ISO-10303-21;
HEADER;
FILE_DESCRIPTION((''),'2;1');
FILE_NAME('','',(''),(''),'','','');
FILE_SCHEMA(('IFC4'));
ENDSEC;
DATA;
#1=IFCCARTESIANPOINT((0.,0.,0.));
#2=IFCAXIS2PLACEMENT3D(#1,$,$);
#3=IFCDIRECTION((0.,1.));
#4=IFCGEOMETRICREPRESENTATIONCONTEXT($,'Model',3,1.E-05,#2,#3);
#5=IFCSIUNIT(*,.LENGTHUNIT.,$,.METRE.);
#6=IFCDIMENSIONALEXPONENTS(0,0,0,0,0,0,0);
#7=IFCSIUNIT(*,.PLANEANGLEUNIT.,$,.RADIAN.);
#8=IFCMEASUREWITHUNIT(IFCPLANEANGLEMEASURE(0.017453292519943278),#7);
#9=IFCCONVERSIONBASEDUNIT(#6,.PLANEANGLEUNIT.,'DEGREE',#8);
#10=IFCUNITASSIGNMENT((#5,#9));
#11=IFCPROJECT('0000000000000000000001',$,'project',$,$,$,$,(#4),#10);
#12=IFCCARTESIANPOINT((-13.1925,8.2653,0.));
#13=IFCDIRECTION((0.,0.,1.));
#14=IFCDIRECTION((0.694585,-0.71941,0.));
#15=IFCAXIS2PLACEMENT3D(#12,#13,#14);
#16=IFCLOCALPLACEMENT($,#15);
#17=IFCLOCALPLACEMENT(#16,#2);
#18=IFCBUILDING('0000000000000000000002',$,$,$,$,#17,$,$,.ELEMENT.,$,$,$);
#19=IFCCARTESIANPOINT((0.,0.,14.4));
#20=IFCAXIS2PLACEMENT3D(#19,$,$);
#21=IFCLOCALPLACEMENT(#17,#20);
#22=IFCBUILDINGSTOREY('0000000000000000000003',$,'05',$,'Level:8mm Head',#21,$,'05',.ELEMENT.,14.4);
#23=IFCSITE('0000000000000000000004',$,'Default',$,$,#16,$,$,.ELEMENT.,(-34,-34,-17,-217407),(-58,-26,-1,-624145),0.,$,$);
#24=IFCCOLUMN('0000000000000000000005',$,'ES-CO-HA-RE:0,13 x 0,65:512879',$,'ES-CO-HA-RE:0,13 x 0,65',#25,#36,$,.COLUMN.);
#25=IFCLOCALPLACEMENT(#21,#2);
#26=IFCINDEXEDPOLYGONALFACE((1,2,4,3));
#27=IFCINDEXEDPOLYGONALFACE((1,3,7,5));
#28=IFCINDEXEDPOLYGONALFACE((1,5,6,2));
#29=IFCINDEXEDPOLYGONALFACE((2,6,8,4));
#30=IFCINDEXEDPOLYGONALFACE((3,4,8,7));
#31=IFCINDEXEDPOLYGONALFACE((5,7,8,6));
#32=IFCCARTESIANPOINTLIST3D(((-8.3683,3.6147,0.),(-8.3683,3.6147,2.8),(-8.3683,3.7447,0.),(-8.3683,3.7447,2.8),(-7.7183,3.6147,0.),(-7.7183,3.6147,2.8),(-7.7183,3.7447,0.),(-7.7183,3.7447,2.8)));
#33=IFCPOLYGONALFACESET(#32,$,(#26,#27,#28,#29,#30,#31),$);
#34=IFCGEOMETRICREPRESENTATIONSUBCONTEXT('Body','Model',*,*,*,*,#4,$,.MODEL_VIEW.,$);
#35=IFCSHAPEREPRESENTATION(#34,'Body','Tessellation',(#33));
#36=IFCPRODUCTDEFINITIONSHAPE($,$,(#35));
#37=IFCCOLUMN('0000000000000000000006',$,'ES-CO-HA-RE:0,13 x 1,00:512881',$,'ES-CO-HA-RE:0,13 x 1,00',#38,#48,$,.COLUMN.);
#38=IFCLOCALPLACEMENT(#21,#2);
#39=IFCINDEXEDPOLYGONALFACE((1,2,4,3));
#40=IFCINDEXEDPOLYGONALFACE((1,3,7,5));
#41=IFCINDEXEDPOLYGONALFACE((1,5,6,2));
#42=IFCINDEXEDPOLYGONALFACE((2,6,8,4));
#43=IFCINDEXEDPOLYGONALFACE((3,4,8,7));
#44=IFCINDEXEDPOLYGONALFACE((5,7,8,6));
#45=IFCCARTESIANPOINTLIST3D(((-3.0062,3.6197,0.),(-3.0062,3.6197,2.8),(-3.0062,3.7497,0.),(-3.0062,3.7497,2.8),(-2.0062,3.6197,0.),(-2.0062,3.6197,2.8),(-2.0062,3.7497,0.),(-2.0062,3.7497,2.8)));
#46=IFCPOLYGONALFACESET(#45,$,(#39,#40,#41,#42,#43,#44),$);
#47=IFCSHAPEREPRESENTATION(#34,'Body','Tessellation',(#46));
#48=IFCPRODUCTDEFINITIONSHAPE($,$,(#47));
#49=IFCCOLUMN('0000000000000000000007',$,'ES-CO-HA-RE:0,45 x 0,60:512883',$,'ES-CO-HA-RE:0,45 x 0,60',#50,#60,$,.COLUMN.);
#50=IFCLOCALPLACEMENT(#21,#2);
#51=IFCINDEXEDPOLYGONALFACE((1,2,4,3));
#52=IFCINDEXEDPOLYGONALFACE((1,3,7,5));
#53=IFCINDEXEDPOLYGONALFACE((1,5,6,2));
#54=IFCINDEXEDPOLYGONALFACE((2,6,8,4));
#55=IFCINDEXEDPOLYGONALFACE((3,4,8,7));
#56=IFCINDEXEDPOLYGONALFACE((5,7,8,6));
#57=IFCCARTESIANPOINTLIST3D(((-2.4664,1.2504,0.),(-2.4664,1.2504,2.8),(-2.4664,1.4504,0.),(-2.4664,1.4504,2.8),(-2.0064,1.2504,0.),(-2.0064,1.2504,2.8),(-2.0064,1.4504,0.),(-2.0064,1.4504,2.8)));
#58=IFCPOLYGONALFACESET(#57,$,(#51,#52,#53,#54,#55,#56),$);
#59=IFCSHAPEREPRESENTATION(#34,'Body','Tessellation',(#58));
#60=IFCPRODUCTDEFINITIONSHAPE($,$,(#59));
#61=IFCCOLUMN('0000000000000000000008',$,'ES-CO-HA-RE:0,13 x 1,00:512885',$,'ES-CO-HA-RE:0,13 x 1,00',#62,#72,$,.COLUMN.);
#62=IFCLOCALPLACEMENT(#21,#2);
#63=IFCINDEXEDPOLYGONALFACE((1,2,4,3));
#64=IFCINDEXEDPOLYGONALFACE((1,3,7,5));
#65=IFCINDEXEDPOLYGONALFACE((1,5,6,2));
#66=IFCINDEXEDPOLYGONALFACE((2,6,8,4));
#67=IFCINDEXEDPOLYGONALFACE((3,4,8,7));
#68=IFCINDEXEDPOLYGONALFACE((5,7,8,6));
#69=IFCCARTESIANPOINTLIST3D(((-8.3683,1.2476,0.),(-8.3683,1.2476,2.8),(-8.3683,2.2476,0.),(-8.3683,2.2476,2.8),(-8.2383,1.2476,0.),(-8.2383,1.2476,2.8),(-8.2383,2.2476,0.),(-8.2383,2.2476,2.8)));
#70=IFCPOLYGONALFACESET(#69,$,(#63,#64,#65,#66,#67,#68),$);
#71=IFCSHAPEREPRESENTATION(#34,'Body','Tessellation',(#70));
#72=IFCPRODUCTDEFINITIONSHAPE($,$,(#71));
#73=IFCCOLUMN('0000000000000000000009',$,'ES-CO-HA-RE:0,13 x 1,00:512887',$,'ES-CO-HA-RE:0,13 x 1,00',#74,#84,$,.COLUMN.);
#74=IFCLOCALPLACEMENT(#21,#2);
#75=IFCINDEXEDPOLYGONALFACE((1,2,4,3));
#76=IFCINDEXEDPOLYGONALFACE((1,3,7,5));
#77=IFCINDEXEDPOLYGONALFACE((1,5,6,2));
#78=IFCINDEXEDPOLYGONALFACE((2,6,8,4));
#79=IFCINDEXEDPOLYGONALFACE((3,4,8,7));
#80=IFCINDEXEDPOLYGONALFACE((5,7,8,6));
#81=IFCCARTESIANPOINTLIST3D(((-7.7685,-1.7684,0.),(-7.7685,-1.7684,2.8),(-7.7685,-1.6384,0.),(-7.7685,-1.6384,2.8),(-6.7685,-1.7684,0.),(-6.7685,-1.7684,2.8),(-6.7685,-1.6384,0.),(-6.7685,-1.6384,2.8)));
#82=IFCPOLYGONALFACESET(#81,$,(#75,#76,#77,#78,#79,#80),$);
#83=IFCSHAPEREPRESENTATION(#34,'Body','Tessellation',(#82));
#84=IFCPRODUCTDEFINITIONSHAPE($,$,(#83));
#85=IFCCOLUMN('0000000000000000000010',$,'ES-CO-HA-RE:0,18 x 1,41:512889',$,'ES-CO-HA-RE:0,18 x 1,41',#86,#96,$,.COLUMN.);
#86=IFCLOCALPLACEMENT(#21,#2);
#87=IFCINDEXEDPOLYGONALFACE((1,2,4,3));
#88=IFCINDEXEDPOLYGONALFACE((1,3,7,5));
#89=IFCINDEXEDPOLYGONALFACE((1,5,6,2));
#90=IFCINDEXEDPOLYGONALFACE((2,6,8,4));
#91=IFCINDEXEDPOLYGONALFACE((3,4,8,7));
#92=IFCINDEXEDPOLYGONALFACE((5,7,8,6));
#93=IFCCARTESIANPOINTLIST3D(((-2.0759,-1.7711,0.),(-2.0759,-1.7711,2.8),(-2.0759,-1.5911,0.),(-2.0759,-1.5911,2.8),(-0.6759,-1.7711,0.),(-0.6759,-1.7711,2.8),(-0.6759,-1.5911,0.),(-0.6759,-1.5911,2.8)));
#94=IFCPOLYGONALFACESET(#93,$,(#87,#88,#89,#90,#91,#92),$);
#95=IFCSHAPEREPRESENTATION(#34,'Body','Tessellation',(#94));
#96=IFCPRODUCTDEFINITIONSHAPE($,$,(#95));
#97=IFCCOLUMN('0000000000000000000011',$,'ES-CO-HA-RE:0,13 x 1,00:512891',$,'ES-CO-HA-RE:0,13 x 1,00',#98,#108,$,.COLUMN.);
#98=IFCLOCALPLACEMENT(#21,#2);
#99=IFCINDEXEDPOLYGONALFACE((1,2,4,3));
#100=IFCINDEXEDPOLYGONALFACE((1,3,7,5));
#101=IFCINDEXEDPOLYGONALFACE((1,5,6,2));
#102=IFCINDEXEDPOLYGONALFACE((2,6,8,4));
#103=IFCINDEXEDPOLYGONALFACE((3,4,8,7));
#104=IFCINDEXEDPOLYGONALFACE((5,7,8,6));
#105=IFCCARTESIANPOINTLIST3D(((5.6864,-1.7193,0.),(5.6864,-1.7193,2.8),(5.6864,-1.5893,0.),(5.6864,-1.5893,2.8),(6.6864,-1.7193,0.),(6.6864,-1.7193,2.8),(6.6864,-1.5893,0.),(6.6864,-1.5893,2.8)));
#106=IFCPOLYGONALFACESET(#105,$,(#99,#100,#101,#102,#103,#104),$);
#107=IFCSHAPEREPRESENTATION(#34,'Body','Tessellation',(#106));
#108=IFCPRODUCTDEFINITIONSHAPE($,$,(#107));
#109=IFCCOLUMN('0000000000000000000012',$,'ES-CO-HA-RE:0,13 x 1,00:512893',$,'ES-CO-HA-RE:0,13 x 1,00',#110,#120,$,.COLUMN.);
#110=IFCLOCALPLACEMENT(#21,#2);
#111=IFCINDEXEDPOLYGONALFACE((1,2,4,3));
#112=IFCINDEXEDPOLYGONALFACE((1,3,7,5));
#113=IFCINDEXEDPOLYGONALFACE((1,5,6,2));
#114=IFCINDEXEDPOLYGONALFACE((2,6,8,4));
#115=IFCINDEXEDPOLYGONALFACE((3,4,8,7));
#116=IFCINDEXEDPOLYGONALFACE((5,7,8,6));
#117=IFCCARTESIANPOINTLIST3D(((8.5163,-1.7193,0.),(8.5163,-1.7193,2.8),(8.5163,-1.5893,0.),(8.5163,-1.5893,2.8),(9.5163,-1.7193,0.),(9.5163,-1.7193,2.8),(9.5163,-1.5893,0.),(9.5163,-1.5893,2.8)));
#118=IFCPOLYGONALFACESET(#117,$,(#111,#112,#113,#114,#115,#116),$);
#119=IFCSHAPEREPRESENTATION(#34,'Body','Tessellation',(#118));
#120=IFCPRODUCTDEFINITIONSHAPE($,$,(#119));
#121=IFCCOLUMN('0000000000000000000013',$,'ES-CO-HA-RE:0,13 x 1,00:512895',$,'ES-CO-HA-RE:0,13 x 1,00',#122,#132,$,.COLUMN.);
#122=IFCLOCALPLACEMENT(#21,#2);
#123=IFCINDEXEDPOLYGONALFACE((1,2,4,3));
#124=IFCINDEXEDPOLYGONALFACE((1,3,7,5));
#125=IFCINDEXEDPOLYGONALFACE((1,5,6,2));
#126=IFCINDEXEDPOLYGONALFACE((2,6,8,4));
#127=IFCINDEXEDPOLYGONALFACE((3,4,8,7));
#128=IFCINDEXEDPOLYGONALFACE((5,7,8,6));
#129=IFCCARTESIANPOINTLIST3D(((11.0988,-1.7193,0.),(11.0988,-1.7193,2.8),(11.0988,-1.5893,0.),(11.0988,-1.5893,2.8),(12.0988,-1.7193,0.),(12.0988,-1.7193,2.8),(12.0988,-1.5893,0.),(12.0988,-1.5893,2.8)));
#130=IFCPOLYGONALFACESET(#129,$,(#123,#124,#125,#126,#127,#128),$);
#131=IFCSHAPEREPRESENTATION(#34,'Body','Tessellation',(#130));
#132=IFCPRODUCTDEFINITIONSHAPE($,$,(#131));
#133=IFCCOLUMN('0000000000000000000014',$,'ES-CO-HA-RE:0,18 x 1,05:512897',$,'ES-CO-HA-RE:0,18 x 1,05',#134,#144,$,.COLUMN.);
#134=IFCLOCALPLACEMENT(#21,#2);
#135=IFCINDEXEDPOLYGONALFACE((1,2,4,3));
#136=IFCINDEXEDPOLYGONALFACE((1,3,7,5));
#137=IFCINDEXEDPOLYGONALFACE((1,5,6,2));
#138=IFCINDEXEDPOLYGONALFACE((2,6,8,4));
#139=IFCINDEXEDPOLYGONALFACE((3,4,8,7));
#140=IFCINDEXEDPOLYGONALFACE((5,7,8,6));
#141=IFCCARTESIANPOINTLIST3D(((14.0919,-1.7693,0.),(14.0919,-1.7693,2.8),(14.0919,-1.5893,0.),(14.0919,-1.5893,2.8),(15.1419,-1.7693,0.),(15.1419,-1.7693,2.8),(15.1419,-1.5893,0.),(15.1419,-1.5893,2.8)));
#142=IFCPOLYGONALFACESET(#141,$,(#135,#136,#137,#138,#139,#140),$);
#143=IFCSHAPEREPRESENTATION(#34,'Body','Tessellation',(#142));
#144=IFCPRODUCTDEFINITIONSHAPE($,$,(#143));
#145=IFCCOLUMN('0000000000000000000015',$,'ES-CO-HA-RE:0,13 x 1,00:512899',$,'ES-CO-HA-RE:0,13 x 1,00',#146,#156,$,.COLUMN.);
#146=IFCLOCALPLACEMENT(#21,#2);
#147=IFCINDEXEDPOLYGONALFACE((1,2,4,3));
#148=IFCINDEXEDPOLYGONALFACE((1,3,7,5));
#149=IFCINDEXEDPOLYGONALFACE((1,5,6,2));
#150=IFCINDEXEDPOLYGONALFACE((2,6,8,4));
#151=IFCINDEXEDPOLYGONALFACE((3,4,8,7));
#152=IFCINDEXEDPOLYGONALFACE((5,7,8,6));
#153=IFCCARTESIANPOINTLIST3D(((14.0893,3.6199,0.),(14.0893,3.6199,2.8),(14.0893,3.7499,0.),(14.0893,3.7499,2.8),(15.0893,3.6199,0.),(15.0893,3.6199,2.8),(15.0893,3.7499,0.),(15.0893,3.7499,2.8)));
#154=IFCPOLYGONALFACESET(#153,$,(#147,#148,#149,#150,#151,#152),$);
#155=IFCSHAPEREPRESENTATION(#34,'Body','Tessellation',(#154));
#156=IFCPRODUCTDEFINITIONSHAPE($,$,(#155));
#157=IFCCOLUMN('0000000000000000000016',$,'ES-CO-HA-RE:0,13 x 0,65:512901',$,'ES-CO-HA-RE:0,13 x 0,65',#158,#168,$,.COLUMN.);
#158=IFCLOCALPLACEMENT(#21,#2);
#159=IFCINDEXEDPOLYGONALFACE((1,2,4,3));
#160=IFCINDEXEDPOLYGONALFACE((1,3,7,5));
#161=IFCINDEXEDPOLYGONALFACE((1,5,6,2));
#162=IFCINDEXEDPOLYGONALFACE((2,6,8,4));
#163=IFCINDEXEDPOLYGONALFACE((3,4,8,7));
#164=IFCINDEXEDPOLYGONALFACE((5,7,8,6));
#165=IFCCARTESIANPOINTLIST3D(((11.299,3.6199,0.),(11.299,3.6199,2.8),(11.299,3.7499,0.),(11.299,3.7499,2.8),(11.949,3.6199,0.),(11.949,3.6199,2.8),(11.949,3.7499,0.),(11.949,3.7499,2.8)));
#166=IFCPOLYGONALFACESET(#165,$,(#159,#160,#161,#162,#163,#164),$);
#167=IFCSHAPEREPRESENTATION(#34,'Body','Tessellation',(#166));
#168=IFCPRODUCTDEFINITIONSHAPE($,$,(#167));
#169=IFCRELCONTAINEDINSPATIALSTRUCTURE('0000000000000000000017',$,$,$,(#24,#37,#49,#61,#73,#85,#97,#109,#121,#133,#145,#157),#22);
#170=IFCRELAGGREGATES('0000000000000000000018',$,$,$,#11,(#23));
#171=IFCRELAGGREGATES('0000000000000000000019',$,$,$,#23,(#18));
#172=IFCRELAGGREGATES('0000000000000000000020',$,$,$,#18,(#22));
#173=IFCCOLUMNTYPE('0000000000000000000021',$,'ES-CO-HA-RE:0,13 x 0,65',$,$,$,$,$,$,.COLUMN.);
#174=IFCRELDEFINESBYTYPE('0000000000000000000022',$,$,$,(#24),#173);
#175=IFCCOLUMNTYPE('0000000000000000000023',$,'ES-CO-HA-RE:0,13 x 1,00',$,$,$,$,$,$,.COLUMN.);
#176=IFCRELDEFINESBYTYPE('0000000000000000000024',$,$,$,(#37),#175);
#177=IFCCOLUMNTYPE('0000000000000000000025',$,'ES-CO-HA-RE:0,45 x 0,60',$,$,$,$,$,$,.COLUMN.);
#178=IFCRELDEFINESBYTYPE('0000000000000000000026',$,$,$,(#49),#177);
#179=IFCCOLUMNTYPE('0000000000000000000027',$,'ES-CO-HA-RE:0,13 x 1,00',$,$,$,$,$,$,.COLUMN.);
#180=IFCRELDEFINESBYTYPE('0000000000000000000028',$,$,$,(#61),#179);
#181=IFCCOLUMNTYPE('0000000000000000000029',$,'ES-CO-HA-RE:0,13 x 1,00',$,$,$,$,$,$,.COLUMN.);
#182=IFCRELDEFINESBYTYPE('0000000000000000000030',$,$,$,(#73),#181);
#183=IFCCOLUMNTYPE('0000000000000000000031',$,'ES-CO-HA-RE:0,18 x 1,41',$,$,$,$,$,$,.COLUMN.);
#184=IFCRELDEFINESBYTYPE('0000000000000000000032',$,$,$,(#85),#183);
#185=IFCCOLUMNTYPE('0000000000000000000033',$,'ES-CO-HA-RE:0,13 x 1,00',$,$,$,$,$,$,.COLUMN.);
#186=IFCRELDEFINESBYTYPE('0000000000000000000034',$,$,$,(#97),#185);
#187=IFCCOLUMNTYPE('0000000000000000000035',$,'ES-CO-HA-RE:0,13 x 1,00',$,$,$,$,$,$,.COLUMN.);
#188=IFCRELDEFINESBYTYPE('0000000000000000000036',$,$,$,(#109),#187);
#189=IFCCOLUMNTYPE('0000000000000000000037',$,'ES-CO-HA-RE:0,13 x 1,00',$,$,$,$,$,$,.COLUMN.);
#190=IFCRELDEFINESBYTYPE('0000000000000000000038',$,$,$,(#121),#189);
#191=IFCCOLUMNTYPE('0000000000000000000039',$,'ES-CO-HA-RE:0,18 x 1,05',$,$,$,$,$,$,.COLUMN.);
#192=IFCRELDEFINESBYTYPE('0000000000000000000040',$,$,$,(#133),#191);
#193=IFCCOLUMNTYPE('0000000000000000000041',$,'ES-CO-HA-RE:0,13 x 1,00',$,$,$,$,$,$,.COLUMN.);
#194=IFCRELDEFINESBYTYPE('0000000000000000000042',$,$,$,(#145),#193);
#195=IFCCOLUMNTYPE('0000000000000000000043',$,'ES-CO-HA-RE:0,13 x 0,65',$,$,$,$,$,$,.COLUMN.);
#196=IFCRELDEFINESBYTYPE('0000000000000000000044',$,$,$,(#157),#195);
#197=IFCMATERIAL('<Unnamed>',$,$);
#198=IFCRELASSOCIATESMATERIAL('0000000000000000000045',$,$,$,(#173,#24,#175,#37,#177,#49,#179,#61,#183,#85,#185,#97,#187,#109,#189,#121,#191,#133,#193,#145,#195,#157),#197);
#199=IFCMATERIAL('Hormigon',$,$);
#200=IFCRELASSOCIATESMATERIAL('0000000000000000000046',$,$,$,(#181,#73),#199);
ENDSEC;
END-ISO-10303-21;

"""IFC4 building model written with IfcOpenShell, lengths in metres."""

from ifc_helpers import new_model, entity, si_unit, converted_unit, direction, frame, origin, place, context, subcontext, project, spatial, indexed_curve, outline, extrude, source, transform, mapped, material, type_object, type_shapes, element, save


model = new_model("IFC4")

# Units and contexts
model_context = context("Model", 3, precision=1e-05, world=origin(), true_north=direction((0.0, 1.0)))
body_context = subcontext(model_context, "Body", "Model", "MODEL_VIEW")
ifc_project = project(units=[si_unit("LENGTHUNIT", "METRE"), converted_unit("PLANEANGLEUNIT", "DEGREE", entity("IfcPlaneAngleMeasure", 0.017453292519943278), si_unit("PLANEANGLEUNIT", "RADIAN"), dimensions=[0, 0, 0, 0, 0, 0, 0])], contexts=[model_context])

# Site, building, storey
site_placement = place(None, frame((-13.1925, 8.2653, 0.0), z_axis=(0.0, 0.0, 1.0), x_axis=(0.694585, -0.71941, 0.0)))
site = spatial("IfcSite", under=ifc_project, at=site_placement, Name="Default", CompositionType="ELEMENT", RefLatitude=(-34, -34, -17, -217407), RefLongitude=(-58, -26, -1, -624145), RefElevation=0.0)
building_placement = place(site_placement, origin())
building = spatial("IfcBuilding", under=site, at=building_placement, CompositionType="ELEMENT")
storey_placement = place(building_placement, frame((0.0, 0.0, 14.4)))
storey = spatial("IfcBuildingStorey", under=building, at=storey_placement, Name="05", ObjectType="Level:8mm Head", LongName="05", CompositionType="ELEMENT", Elevation=14.4)

# Columns
ifc_material_1 = material(Name="<Unnamed>")
column_type_1 = type_object("IfcColumnType", Name="ES-CO-HA-RE:0,13 x 0,65", PredefinedType="COLUMN", material=ifc_material_1)
shared_shape_1 = source(origin(), body_context, "Body", "SweptSolid", [
    extrude(outline(indexed_curve([(-0.325, -0.065), (0.325, -0.065), (0.325, 0.065), (-0.325, 0.065), (-0.325, -0.065)], self_intersect=False)), frame((-8.0433, 3.6797, 14.4), z_axis=(0.0, 0.0, 1.0), x_axis=(-1.0, 0.0, 0.0)), (0.0, 0.0, 1.0), 2.8),
])
type_shapes(column_type_1, [shared_shape_1])
column_1_placement = place(storey_placement, frame((0.0, 0.0, -14.4)))
element("IfcColumn", 1, at=column_1_placement, inside=storey, type_object=column_type_1, material=ifc_material_1, Name="ES-CO-HA-RE:0,13 x 0,65:512879", ObjectType="ES-CO-HA-RE:0,13 x 0,65", PredefinedType="COLUMN", context=body_context, shape_type="MappedRepresentation", body=[
    mapped(shared_shape_1, transform((0.0, 0.0, 0.0), scale=1.0)),
])
column_type_2 = type_object("IfcColumnType", Name="ES-CO-HA-RE:0,13 x 1,00", PredefinedType="COLUMN", material=ifc_material_1)
shared_shape_2 = source(origin(), body_context, "Body", "SweptSolid", [
    extrude(outline(indexed_curve([(-0.5, -0.065), (0.5, -0.065), (0.5, 0.065), (-0.5, 0.065), (-0.5, -0.065)], self_intersect=False)), frame((-2.5062, 3.6847, 14.4), z_axis=(0.0, 0.0, 1.0), x_axis=(-1.0, 0.0, 0.0)), (0.0, 0.0, 1.0), 2.8),
])
type_shapes(column_type_2, [shared_shape_2])
column_2_placement = place(storey_placement, frame((0.0, 0.0, -14.4)))
element("IfcColumn", 2, at=column_2_placement, inside=storey, type_object=column_type_2, material=ifc_material_1, Name="ES-CO-HA-RE:0,13 x 1,00:512881", ObjectType="ES-CO-HA-RE:0,13 x 1,00", PredefinedType="COLUMN", context=body_context, shape_type="MappedRepresentation", body=[
    mapped(shared_shape_2, transform((0.0, 0.0, 0.0), scale=1.0)),
])
column_type_3 = type_object("IfcColumnType", Name="ES-CO-HA-RE:0,45 x 0,60", PredefinedType="COLUMN", material=ifc_material_1)
shared_shape_3 = source(origin(), body_context, "Body", "SweptSolid", [
    extrude(outline(indexed_curve([(-0.23, -0.1), (0.23, -0.1), (0.23, 0.1), (-0.23, 0.1), (-0.23, -0.1)], self_intersect=False)), frame((-2.2364, 1.3504, 14.4), z_axis=(0.0, 0.0, 1.0), x_axis=(-1.0, 0.0, 0.0)), (0.0, 0.0, 1.0), 2.8),
])
type_shapes(column_type_3, [shared_shape_3])
column_3_placement = place(storey_placement, frame((0.0, 0.0, -14.4)))
element("IfcColumn", 3, at=column_3_placement, inside=storey, type_object=column_type_3, material=ifc_material_1, Name="ES-CO-HA-RE:0,45 x 0,60:512883", ObjectType="ES-CO-HA-RE:0,45 x 0,60", PredefinedType="COLUMN", context=body_context, shape_type="MappedRepresentation", body=[
    mapped(shared_shape_3, transform((0.0, 0.0, 0.0), scale=1.0)),
])
column_type_4 = type_object("IfcColumnType", Name="ES-CO-HA-RE:0,13 x 1,00", PredefinedType="COLUMN", material=ifc_material_1)
shared_shape_4 = source(origin(), body_context, "Body", "SweptSolid", [
    extrude(outline(indexed_curve([(-0.5, -0.065), (0.5, -0.065), (0.5, 0.065), (-0.5, 0.065), (-0.5, -0.065)], self_intersect=False)), frame((-8.3033, 1.7476, 14.4), z_axis=(0.0, 0.0, 1.0), x_axis=(0.0, -1.0, 0.0)), (0.0, 0.0, 1.0), 2.8),
])
type_shapes(column_type_4, [shared_shape_4])
column_4_placement = place(storey_placement, frame((0.0, 0.0, -14.4)))
element("IfcColumn", 4, at=column_4_placement, inside=storey, type_object=column_type_4, material=ifc_material_1, Name="ES-CO-HA-RE:0,13 x 1,00:512885", ObjectType="ES-CO-HA-RE:0,13 x 1,00", PredefinedType="COLUMN", context=body_context, shape_type="MappedRepresentation", body=[
    mapped(shared_shape_4, transform((0.0, 0.0, 0.0), scale=1.0)),
])
ifc_material_2 = material(Name="Hormigon")
column_type_5 = type_object("IfcColumnType", Name="ES-CO-HA-RE:0,13 x 1,00", PredefinedType="COLUMN", material=ifc_material_2)
shared_shape_5 = source(origin(), body_context, "Body", "SweptSolid", [
    extrude(outline(indexed_curve([(-0.5, -0.065), (0.5, -0.065), (0.5, 0.065), (-0.5, 0.065), (-0.5, -0.065)], self_intersect=False)), frame((-7.2685, -1.7034, 14.4), z_axis=(0.0, 0.0, 1.0), x_axis=(-1.0, 0.0, 0.0)), (0.0, 0.0, 1.0), 2.8),
])
type_shapes(column_type_5, [shared_shape_5])
column_5_placement = place(storey_placement, frame((0.0, 0.0, -14.4)))
element("IfcColumn", 5, at=column_5_placement, inside=storey, type_object=column_type_5, material=ifc_material_2, Name="ES-CO-HA-RE:0,13 x 1,00:512887", ObjectType="ES-CO-HA-RE:0,13 x 1,00", PredefinedType="COLUMN", context=body_context, shape_type="MappedRepresentation", body=[
    mapped(shared_shape_5, transform((0.0, 0.0, 0.0), scale=1.0)),
])
column_type_6 = type_object("IfcColumnType", Name="ES-CO-HA-RE:0,18 x 1,41", PredefinedType="COLUMN", material=ifc_material_1)
shared_shape_6 = source(origin(), body_context, "Body", "SweptSolid", [
    extrude(outline(indexed_curve([(-0.7, -0.09), (0.7, -0.09), (0.7, 0.09), (-0.7, 0.09), (-0.7, -0.09)], self_intersect=False)), frame((-1.3759, -1.6811, 14.4), z_axis=(0.0, 0.0, 1.0), x_axis=(-1.0, 0.0, 0.0)), (0.0, 0.0, 1.0), 2.8),
])
type_shapes(column_type_6, [shared_shape_6])
column_6_placement = place(storey_placement, frame((0.0, 0.0, -14.4)))
element("IfcColumn", 6, at=column_6_placement, inside=storey, type_object=column_type_6, material=ifc_material_1, Name="ES-CO-HA-RE:0,18 x 1,41:512889", ObjectType="ES-CO-HA-RE:0,18 x 1,41", PredefinedType="COLUMN", context=body_context, shape_type="MappedRepresentation", body=[
    mapped(shared_shape_6, transform((0.0, 0.0, 0.0), scale=1.0)),
])
column_type_7 = type_object("IfcColumnType", Name="ES-CO-HA-RE:0,13 x 1,00", PredefinedType="COLUMN", material=ifc_material_1)
shared_shape_7 = source(origin(), body_context, "Body", "SweptSolid", [
    extrude(outline(indexed_curve([(-0.5, -0.065), (0.5, -0.065), (0.5, 0.065), (-0.5, 0.065), (-0.5, -0.065)], self_intersect=False)), frame((6.1864, -1.6543, 14.4), z_axis=(0.0, 0.0, 1.0), x_axis=(-1.0, 0.0, 0.0)), (0.0, 0.0, 1.0), 2.8),
])
type_shapes(column_type_7, [shared_shape_7])
column_7_placement = place(storey_placement, frame((0.0, 0.0, -14.4)))
element("IfcColumn", 7, at=column_7_placement, inside=storey, type_object=column_type_7, material=ifc_material_1, Name="ES-CO-HA-RE:0,13 x 1,00:512891", ObjectType="ES-CO-HA-RE:0,13 x 1,00", PredefinedType="COLUMN", context=body_context, shape_type="MappedRepresentation", body=[
    mapped(shared_shape_7, transform((0.0, 0.0, 0.0), scale=1.0)),
])
column_type_8 = type_object("IfcColumnType", Name="ES-CO-HA-RE:0,13 x 1,00", PredefinedType="COLUMN", material=ifc_material_1)
shared_shape_8 = source(origin(), body_context, "Body", "SweptSolid", [
    extrude(outline(indexed_curve([(-0.5, -0.065), (0.5, -0.065), (0.5, 0.065), (-0.5, 0.065), (-0.5, -0.065)], self_intersect=False)), frame((9.0163, -1.6543, 14.4), z_axis=(0.0, 0.0, 1.0), x_axis=(-1.0, 0.0, 0.0)), (0.0, 0.0, 1.0), 2.8),
])
type_shapes(column_type_8, [shared_shape_8])
column_8_placement = place(storey_placement, frame((0.0, 0.0, -14.4)))
element("IfcColumn", 8, at=column_8_placement, inside=storey, type_object=column_type_8, material=ifc_material_1, Name="ES-CO-HA-RE:0,13 x 1,00:512893", ObjectType="ES-CO-HA-RE:0,13 x 1,00", PredefinedType="COLUMN", context=body_context, shape_type="MappedRepresentation", body=[
    mapped(shared_shape_8, transform((0.0, 0.0, 0.0), scale=1.0)),
])
column_type_9 = type_object("IfcColumnType", Name="ES-CO-HA-RE:0,13 x 1,00", PredefinedType="COLUMN", material=ifc_material_1)
shared_shape_9 = source(origin(), body_context, "Body", "SweptSolid", [
    extrude(outline(indexed_curve([(-0.5, -0.065), (0.5, -0.065), (0.5, 0.065), (-0.5, 0.065), (-0.5, -0.065)], self_intersect=False)), frame((11.5988, -1.6543, 14.4), z_axis=(0.0, 0.0, 1.0), x_axis=(-1.0, 0.0, 0.0)), (0.0, 0.0, 1.0), 2.8),
])
type_shapes(column_type_9, [shared_shape_9])
column_9_placement = place(storey_placement, frame((0.0, 0.0, -14.4)))
element("IfcColumn", 9, at=column_9_placement, inside=storey, type_object=column_type_9, material=ifc_material_1, Name="ES-CO-HA-RE:0,13 x 1,00:512895", ObjectType="ES-CO-HA-RE:0,13 x 1,00", PredefinedType="COLUMN", context=body_context, shape_type="MappedRepresentation", body=[
    mapped(shared_shape_9, transform((0.0, 0.0, 0.0), scale=1.0)),
])
column_type_10 = type_object("IfcColumnType", Name="ES-CO-HA-RE:0,18 x 1,05", PredefinedType="COLUMN", material=ifc_material_1)
shared_shape_10 = source(origin(), body_context, "Body", "SweptSolid", [
    extrude(outline(indexed_curve([(-0.525, -0.09), (0.525, -0.09), (0.525, 0.09), (-0.525, 0.09), (-0.525, -0.09)], self_intersect=False)), frame((14.6169, -1.6793, 14.4), z_axis=(0.0, 0.0, 1.0), x_axis=(-1.0, 0.0, 0.0)), (0.0, 0.0, 1.0), 2.8),
])
type_shapes(column_type_10, [shared_shape_10])
column_10_placement = place(storey_placement, frame((0.0, 0.0, -14.4)))
element("IfcColumn", 10, at=column_10_placement, inside=storey, type_object=column_type_10, material=ifc_material_1, Name="ES-CO-HA-RE:0,18 x 1,05:512897", ObjectType="ES-CO-HA-RE:0,18 x 1,05", PredefinedType="COLUMN", context=body_context, shape_type="MappedRepresentation", body=[
    mapped(shared_shape_10, transform((0.0, 0.0, 0.0), scale=1.0)),
])
column_type_11 = type_object("IfcColumnType", Name="ES-CO-HA-RE:0,13 x 1,00", PredefinedType="COLUMN", material=ifc_material_1)
shared_shape_11 = source(origin(), body_context, "Body", "SweptSolid", [
    extrude(outline(indexed_curve([(-0.5, -0.065), (0.5, -0.065), (0.5, 0.065), (-0.5, 0.065), (-0.5, -0.065)], self_intersect=False)), frame((14.5893, 3.6849, 14.4), z_axis=(0.0, 0.0, 1.0), x_axis=(-1.0, 0.0, 0.0)), (0.0, 0.0, 1.0), 2.8),
])
type_shapes(column_type_11, [shared_shape_11])
column_11_placement = place(storey_placement, frame((0.0, 0.0, -14.4)))
element("IfcColumn", 11, at=column_11_placement, inside=storey, type_object=column_type_11, material=ifc_material_1, Name="ES-CO-HA-RE:0,13 x 1,00:512899", ObjectType="ES-CO-HA-RE:0,13 x 1,00", PredefinedType="COLUMN", context=body_context, shape_type="MappedRepresentation", body=[
    mapped(shared_shape_11, transform((0.0, 0.0, 0.0), scale=1.0)),
])
column_type_12 = type_object("IfcColumnType", Name="ES-CO-HA-RE:0,13 x 0,65", PredefinedType="COLUMN", material=ifc_material_1)
shared_shape_12 = source(origin(), body_context, "Body", "SweptSolid", [
    extrude(outline(indexed_curve([(-0.325, -0.065), (0.325, -0.065), (0.325, 0.065), (-0.325, 0.065), (-0.325, -0.065)], self_intersect=False)), frame((11.624, 3.6849, 14.4), z_axis=(0.0, 0.0, 1.0), x_axis=(-1.0, 0.0, 0.0)), (0.0, 0.0, 1.0), 2.8),
])
type_shapes(column_type_12, [shared_shape_12])
column_12_placement = place(storey_placement, frame((0.0, 0.0, -14.4)))
element("IfcColumn", 12, at=column_12_placement, inside=storey, type_object=column_type_12, material=ifc_material_1, Name="ES-CO-HA-RE:0,13 x 0,65:512901", ObjectType="ES-CO-HA-RE:0,13 x 0,65", PredefinedType="COLUMN", context=body_context, shape_type="MappedRepresentation", body=[
    mapped(shared_shape_12, transform((0.0, 0.0, 0.0), scale=1.0)),
])

save(model, "model.ifc")
